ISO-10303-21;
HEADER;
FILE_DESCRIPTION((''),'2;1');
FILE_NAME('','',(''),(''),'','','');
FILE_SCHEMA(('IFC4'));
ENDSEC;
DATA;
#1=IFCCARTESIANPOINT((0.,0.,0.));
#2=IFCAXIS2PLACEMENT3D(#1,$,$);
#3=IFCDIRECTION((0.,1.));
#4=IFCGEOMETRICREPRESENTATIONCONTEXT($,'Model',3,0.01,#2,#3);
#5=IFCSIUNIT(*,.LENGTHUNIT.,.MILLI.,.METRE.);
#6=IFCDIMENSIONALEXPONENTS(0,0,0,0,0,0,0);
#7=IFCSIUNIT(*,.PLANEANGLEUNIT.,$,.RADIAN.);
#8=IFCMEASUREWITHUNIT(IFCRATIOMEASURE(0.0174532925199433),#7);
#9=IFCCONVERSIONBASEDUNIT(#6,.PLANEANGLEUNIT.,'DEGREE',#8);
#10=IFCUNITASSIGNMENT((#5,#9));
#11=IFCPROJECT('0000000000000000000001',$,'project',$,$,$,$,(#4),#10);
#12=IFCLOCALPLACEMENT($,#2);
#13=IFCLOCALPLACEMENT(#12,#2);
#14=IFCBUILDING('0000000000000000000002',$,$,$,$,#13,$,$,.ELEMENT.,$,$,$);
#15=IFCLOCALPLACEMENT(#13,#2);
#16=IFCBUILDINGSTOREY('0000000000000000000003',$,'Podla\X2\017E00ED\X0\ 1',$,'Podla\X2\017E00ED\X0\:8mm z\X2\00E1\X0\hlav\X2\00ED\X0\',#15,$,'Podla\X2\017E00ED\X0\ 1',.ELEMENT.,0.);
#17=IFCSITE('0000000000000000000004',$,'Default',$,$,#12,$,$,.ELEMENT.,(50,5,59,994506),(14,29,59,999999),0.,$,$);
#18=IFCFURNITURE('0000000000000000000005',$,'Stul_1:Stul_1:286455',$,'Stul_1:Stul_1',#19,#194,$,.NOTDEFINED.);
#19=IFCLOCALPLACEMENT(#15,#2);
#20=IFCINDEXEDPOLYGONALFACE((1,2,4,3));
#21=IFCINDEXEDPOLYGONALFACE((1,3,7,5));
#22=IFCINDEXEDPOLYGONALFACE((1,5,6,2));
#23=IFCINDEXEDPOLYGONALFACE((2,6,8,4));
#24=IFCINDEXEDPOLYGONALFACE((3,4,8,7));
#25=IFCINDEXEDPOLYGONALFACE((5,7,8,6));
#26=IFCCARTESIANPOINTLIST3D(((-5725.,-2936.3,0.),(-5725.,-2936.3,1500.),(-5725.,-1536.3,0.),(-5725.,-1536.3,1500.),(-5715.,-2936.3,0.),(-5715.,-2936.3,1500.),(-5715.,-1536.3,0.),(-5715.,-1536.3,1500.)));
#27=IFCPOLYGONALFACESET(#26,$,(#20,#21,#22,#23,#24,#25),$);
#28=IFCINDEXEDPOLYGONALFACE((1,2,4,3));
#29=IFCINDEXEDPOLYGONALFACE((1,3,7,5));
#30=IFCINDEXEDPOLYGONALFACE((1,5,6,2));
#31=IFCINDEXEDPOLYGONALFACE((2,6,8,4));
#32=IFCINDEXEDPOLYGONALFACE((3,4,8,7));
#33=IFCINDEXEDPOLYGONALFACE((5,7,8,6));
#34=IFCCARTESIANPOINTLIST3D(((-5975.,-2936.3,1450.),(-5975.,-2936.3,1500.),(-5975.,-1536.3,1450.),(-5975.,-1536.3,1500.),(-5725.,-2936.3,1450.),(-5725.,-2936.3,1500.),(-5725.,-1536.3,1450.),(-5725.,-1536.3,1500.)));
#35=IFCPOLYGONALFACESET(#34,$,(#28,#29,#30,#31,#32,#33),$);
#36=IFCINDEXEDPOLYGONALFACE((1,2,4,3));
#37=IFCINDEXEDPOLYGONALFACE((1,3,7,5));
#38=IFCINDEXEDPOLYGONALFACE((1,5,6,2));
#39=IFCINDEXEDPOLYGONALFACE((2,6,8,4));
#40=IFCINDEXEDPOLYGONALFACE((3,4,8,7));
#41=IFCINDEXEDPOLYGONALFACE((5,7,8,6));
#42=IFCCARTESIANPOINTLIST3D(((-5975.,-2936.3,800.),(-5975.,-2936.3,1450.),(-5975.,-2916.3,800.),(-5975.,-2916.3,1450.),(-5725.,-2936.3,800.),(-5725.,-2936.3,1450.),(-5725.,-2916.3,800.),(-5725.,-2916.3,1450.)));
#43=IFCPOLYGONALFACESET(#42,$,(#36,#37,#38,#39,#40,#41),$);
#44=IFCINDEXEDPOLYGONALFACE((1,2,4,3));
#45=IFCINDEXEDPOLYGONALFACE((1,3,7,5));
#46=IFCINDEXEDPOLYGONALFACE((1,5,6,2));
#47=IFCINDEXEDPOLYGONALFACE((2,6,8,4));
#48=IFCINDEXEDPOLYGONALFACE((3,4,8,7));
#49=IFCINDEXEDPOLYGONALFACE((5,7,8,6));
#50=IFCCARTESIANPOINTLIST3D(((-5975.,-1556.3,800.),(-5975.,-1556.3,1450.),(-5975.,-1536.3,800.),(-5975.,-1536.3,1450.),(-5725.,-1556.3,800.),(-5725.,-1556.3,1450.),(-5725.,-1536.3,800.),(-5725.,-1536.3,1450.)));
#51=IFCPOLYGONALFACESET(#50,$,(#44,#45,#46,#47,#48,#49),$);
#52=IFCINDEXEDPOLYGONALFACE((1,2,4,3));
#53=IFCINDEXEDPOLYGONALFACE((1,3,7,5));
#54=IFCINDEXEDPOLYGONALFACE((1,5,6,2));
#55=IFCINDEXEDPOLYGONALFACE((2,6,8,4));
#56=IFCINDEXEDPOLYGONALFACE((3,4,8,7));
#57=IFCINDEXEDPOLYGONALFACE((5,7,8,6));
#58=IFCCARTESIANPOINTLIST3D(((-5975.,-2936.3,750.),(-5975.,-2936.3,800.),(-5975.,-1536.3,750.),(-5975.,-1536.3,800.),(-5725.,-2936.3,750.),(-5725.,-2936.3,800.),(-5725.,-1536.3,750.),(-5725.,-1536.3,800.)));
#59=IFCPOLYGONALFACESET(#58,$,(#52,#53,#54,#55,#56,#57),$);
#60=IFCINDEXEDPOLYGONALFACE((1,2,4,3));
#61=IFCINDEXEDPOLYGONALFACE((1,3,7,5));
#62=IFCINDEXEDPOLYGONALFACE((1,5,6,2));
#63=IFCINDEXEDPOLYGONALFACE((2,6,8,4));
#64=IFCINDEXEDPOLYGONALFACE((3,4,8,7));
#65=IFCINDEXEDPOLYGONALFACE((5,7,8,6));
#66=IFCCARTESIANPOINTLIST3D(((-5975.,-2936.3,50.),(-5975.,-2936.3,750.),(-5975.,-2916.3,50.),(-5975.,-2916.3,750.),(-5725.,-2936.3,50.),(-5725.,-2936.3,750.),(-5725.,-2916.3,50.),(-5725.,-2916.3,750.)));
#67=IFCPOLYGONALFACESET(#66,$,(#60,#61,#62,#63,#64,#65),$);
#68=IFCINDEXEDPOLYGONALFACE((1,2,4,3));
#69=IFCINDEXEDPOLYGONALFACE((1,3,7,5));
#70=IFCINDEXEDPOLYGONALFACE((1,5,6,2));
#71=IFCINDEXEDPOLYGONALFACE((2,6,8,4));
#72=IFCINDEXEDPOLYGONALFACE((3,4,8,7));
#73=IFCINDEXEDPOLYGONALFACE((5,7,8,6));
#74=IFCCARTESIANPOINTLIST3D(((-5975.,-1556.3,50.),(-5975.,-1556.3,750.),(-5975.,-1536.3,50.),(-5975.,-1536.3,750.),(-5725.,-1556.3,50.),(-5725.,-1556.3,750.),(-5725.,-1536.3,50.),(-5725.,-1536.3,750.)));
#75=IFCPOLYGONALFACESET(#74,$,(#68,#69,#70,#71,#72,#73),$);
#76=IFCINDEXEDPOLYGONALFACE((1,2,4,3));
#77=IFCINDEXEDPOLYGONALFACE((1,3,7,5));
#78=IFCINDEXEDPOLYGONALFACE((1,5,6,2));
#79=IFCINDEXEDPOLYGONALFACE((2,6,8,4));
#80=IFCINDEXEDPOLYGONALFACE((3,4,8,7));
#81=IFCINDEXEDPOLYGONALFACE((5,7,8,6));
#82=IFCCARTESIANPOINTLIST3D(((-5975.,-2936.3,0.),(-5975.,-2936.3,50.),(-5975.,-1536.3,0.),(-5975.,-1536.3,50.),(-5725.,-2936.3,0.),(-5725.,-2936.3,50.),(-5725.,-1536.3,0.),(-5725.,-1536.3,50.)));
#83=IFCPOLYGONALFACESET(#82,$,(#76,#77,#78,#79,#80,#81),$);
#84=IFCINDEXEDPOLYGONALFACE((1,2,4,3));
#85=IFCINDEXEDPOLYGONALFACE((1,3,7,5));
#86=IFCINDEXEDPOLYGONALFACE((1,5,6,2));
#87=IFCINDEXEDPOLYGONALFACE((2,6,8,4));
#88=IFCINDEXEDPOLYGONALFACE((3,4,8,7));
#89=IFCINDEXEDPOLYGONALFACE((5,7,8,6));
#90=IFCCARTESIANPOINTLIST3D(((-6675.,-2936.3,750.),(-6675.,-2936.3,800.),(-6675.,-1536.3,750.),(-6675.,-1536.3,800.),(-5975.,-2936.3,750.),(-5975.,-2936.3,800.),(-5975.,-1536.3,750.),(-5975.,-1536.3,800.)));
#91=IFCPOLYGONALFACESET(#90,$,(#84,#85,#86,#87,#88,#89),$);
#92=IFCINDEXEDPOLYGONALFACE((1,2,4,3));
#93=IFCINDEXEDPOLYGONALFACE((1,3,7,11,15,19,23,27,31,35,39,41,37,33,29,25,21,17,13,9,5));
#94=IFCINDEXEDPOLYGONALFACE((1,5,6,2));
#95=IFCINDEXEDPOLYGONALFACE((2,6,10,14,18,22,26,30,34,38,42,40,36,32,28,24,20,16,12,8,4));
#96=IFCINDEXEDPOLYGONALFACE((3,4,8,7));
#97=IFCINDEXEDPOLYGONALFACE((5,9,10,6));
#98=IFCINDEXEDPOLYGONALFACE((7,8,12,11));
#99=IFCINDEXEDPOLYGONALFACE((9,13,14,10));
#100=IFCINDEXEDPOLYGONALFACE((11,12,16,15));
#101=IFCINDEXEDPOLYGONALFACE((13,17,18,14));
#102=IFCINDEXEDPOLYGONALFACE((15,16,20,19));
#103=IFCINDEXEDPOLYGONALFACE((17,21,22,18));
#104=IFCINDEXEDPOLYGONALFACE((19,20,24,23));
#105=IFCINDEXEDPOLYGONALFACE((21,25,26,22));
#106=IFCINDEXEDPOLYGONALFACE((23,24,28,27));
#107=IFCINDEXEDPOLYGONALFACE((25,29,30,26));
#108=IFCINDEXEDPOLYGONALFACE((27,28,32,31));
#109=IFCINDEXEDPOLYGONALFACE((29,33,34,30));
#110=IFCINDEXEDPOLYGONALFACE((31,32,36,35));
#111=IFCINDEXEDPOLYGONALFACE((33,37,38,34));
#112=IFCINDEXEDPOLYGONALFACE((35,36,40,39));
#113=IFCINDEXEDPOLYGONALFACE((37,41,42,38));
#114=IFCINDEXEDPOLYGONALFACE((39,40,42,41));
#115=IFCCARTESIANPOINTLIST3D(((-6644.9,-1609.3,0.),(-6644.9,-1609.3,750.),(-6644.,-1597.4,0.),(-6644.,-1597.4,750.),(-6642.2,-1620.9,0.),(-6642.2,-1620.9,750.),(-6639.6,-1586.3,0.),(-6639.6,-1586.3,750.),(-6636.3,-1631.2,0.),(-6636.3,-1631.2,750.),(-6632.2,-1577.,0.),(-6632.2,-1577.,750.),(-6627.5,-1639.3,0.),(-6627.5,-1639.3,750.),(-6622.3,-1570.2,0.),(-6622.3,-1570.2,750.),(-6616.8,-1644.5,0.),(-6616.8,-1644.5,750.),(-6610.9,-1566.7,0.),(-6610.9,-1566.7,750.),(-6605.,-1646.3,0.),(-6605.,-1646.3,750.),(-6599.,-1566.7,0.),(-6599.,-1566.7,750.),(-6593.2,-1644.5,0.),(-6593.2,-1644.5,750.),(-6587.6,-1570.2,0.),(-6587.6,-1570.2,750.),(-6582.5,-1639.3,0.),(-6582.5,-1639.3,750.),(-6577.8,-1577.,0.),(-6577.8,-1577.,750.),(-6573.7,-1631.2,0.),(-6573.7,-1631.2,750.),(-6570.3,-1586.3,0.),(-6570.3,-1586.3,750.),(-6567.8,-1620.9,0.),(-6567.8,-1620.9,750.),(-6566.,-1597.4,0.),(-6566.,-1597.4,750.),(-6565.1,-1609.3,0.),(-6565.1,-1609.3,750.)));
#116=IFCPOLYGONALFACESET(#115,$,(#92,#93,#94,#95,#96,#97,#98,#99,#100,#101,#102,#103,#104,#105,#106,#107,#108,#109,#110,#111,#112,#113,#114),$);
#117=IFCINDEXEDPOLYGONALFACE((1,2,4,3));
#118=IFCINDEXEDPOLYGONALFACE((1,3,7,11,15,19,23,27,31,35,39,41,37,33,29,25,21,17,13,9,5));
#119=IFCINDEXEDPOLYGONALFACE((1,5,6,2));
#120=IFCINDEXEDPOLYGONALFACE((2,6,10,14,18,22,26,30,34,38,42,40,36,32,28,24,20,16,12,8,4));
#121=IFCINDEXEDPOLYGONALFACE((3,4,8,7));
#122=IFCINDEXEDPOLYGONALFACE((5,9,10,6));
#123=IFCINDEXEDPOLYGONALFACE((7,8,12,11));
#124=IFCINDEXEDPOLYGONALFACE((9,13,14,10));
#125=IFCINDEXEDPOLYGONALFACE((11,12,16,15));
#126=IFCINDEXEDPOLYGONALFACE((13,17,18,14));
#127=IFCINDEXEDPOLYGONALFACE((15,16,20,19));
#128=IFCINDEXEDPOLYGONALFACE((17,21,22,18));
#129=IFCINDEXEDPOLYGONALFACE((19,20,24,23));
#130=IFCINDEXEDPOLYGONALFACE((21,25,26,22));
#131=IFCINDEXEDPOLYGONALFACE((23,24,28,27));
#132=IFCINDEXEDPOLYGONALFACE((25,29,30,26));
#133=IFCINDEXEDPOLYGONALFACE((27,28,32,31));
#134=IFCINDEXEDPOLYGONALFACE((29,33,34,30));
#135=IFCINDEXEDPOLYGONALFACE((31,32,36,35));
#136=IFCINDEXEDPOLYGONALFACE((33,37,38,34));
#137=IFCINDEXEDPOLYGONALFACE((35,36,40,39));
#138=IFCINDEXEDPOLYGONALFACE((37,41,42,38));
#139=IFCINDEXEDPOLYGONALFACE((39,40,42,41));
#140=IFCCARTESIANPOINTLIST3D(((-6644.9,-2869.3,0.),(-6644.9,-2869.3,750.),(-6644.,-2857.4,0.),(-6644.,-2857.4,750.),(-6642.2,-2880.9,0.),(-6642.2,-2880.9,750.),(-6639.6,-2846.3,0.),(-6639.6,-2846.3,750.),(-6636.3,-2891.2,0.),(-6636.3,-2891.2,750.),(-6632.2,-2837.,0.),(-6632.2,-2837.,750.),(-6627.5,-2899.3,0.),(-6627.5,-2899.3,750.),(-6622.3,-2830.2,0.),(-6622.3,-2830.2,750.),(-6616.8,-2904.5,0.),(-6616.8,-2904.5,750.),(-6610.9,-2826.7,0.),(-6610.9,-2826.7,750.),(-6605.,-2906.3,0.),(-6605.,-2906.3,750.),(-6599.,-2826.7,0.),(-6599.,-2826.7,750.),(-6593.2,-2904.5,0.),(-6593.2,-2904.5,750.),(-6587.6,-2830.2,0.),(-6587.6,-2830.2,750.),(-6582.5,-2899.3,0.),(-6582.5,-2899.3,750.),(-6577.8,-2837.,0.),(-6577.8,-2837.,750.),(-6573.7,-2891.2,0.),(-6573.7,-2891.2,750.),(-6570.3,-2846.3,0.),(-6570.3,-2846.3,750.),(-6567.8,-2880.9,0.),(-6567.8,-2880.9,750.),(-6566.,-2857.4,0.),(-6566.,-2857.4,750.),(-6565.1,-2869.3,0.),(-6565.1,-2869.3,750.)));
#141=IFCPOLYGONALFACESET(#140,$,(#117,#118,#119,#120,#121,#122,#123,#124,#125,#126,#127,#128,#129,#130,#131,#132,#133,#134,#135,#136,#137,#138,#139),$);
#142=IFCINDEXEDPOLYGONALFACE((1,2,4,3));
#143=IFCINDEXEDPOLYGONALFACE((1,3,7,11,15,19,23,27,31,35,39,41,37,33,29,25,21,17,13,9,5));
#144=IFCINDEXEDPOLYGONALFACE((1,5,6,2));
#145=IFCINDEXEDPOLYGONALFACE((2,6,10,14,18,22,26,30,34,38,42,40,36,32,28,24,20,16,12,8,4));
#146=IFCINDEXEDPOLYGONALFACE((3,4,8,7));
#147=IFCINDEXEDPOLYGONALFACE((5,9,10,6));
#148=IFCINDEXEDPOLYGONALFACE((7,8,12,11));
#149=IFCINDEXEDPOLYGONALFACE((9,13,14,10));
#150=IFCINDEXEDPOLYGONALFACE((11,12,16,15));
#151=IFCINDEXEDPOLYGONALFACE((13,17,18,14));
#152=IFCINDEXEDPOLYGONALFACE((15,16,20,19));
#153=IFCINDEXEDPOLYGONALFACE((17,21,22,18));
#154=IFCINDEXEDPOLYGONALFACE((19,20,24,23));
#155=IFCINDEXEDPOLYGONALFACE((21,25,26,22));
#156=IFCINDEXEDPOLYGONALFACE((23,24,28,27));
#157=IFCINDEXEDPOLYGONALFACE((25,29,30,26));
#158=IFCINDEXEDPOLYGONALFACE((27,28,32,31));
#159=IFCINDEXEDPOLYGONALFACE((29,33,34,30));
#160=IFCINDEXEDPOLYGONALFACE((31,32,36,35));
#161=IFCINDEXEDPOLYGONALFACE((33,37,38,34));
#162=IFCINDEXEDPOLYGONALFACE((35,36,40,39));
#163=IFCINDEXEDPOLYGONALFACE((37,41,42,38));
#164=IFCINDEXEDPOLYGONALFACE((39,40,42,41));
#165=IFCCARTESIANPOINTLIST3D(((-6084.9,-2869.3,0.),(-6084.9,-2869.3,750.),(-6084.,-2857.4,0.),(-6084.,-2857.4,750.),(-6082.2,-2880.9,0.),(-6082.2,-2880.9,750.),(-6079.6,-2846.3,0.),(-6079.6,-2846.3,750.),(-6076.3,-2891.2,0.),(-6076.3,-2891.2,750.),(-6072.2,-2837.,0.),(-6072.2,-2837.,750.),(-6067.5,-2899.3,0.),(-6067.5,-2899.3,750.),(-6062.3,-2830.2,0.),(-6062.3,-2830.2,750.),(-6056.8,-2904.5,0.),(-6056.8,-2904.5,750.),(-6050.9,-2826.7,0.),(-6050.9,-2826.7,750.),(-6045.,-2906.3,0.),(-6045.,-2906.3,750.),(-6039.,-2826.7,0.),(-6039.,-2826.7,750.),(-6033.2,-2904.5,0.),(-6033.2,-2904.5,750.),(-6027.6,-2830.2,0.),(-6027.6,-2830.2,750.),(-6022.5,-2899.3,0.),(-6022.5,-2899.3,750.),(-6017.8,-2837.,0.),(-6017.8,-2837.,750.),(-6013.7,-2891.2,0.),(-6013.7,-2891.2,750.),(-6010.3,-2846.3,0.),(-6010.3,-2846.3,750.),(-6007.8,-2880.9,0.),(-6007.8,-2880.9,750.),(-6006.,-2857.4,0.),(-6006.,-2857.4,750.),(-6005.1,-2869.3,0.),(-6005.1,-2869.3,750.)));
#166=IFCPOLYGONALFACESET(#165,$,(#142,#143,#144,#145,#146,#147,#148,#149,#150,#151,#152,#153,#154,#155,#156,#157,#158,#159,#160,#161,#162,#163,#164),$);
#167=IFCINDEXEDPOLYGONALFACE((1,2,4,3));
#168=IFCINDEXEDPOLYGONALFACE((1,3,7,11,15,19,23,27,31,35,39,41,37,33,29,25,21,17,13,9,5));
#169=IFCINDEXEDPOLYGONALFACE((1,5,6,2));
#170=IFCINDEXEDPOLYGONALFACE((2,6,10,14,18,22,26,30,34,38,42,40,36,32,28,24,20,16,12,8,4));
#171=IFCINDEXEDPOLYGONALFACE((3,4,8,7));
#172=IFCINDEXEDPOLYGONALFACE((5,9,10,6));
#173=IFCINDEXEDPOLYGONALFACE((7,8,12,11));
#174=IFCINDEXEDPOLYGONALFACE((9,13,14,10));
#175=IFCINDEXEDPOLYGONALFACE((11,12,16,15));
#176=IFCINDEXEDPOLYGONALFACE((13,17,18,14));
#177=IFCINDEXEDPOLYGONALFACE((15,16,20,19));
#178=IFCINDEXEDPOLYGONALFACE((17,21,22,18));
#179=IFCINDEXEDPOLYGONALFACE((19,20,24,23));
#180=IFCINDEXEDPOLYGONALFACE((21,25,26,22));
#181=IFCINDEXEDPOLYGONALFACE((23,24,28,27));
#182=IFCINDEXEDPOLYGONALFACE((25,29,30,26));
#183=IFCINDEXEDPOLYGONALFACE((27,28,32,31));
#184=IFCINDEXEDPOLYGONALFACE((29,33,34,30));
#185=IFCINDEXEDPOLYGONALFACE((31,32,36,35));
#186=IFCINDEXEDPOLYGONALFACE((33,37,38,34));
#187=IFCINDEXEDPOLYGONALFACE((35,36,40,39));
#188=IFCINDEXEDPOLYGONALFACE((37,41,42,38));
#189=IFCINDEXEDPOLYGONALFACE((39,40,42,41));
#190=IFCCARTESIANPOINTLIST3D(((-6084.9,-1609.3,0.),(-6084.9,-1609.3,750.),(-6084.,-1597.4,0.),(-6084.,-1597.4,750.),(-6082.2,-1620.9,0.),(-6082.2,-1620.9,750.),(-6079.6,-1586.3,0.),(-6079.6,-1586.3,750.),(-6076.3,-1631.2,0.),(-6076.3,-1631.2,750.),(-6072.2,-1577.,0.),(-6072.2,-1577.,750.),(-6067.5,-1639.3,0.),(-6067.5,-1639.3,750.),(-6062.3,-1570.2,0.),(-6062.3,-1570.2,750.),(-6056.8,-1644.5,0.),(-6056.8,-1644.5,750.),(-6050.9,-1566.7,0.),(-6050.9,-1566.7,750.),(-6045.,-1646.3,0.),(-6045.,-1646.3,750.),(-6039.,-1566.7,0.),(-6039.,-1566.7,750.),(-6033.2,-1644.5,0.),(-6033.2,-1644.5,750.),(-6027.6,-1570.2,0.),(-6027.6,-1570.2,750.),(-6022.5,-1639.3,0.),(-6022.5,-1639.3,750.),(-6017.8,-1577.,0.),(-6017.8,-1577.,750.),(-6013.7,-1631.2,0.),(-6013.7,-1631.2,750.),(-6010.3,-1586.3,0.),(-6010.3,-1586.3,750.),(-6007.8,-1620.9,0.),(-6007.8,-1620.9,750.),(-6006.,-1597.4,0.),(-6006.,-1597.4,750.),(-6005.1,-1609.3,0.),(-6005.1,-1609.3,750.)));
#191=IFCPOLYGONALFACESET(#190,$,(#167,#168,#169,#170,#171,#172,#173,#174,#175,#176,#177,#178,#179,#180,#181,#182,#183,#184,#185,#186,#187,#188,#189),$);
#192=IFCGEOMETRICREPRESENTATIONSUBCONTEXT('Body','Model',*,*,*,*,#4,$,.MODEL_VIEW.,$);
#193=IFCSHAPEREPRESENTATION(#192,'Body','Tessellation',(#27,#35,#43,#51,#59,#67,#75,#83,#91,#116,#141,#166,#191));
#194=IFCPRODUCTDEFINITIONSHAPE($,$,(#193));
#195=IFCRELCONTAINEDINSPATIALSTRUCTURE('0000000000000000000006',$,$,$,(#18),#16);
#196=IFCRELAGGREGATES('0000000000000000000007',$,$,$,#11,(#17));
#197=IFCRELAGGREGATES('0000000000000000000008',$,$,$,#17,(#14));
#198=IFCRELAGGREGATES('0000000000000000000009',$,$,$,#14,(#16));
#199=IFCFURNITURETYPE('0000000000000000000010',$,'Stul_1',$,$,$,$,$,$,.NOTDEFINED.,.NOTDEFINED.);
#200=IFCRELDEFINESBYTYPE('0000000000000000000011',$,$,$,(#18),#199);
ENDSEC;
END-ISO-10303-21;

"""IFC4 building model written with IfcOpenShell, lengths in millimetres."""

from ifc_helpers import new_model, entity, si_unit, converted_unit, direction, frame, frame_2d, origin, origin_2d_with_axis, place, context, subcontext, project, spatial, rectangle, circle, extrude, source, transform, mapped, type_object, type_shapes, element, save


model = new_model("IFC4")

# Units and contexts
model_context = context("Model", 3, precision=0.01, world=origin(), true_north=direction((0.0, 1.0)))
body_context = subcontext(model_context, "Body", "Model", "MODEL_VIEW")
ifc_project = project(units=[si_unit("LENGTHUNIT", "METRE", prefix="MILLI"), converted_unit("PLANEANGLEUNIT", "DEGREE", entity("IfcRatioMeasure", 0.0174532925199433), si_unit("PLANEANGLEUNIT", "RADIAN"), dimensions=[0, 0, 0, 0, 0, 0, 0])], contexts=[model_context])

# Site, building, storey
site_placement = place(None, origin())
site = spatial("IfcSite", under=ifc_project, at=site_placement, Name="Default", CompositionType="ELEMENT", RefLatitude=(50, 5, 59, 994506), RefLongitude=(14, 29, 59, 999999), RefElevation=0.0)
building_placement = place(site_placement, origin())
building = spatial("IfcBuilding", under=site, at=building_placement, CompositionType="ELEMENT")
storey_placement = place(building_placement, origin())
storey = spatial("IfcBuildingStorey", under=building, at=storey_placement, Name="Podlaží 1", ObjectType="Podlaží:8mm záhlaví", LongName="Podlaží 1", CompositionType="ELEMENT", Elevation=0.0)

# Furniture
furniture_type = type_object("IfcFurnitureType", Name="Stul_1", AssemblyPlace="NOTDEFINED", PredefinedType="NOTDEFINED")
shared_shape_1 = source(origin(), body_context, "Body", "SweptSolid", [
    extrude(rectangle(XDim=1400.0, YDim=10.0, at=origin_2d_with_axis()), frame((0.0, 605.0, 0.0), z_axis=(0.0, 0.0, 1.0), x_axis=(-1.0, 0.0, 0.0)), (0.0, 0.0, 1.0), 1500.0),
    extrude(rectangle(XDim=1400.0, YDim=250.0, at=frame_2d((0.0, 0.0), x_axis=(1.0, 0.0))), frame((0.0, 475.0, 1450.0), z_axis=(0.0, 0.0, 1.0), x_axis=(-1.0, 0.0, 0.0)), (0.0, 0.0, 1.0), 50.0),
    extrude(rectangle(XDim=20.0, YDim=250.0, at=origin_2d_with_axis()), frame((690.0, 475.0, 800.0), z_axis=(0.0, 0.0, 1.0), x_axis=(-1.0, 0.0, 0.0)), (0.0, 0.0, 1.0), 650.0),
    extrude(rectangle(XDim=20.0, YDim=250.0, at=frame_2d((0.0, 0.0), x_axis=(1.0, 0.0))), frame((-690.0, 475.0, 800.0), z_axis=(0.0, 0.0, 1.0), x_axis=(-1.0, 0.0, 0.0)), (0.0, 0.0, 1.0), 650.0),
    extrude(rectangle(XDim=1400.0, YDim=250.0, at=origin_2d_with_axis()), frame((0.0, 475.0, 750.0), z_axis=(0.0, 0.0, 1.0), x_axis=(-1.0, 0.0, 0.0)), (0.0, 0.0, 1.0), 50.0),
    extrude(rectangle(XDim=20.0, YDim=250.0, at=origin_2d_with_axis()), frame((690.0, 475.0, 50.0), z_axis=(0.0, 0.0, 1.0), x_axis=(-1.0, 0.0, 0.0)), (0.0, 0.0, 1.0), 700.0),
    extrude(rectangle(XDim=20.0, YDim=250.0, at=frame_2d((0.0, 0.0), x_axis=(1.0, 0.0))), frame((-690.0, 475.0, 50.0), z_axis=(0.0, 0.0, 1.0), x_axis=(-1.0, 0.0, 0.0)), (0.0, 0.0, 1.0), 700.0),
    extrude(rectangle(XDim=1400.0, YDim=250.0, at=origin_2d_with_axis()), frame((0.0, 475.0, 0.0), z_axis=(0.0, 0.0, 1.0), x_axis=(-1.0, 0.0, 0.0)), (0.0, 0.0, 1.0), 50.0),
    extrude(rectangle(XDim=1400.0, YDim=700.0, at=origin_2d_with_axis()), frame((0.0, 0.0, 750.0), z_axis=(0.0, 0.0, 1.0), x_axis=(-1.0, 0.0, 0.0)), (0.0, 0.0, 1.0), 50.0),
    extrude(circle(Radius=40.0, at=frame_2d((0.0, 0.0), x_axis=(1.0, 0.0))), frame((-630.0, -280.0, 0.0)), (0.0, 0.0, 1.0), 750.0),
    extrude(circle(Radius=40.0, at=frame_2d((0.0, 0.0), x_axis=(1.0, 0.0))), frame((630.0, -280.0, 0.0)), (0.0, 0.0, 1.0), 750.0),
    extrude(circle(Radius=40.0, at=frame_2d((0.0, 0.0), x_axis=(1.0, 0.0))), frame((630.0, 280.0, 0.0)), (0.0, 0.0, 1.0), 750.0),
    extrude(circle(Radius=40.0, at=frame_2d((0.0, 0.0), x_axis=(1.0, 0.0))), frame((-630.0, 280.0, 0.0)), (0.0, 0.0, 1.0), 750.0),
])
type_shapes(furniture_type, [shared_shape_1])
for number, where, z_axis, x_axis, name in (
    (1, (-6325.0, -2236.3, 0.0), (0.0, 0.0, 1.0), (0.0, -1.0, 0.0), "Stul_1:Stul_1:286455"),
):
    element("IfcFurniture", number, at=place(storey_placement, frame(where, z_axis=z_axis, x_axis=x_axis)), inside=storey, type_object=furniture_type, Name=name, ObjectType="Stul_1:Stul_1", PredefinedType="NOTDEFINED", context=body_context, shape_type="MappedRepresentation", body=[
        mapped(shared_shape_1, transform((0.0, 0.0, 0.0), scale=1.0)),
    ])

save(model, "model.ifc")
